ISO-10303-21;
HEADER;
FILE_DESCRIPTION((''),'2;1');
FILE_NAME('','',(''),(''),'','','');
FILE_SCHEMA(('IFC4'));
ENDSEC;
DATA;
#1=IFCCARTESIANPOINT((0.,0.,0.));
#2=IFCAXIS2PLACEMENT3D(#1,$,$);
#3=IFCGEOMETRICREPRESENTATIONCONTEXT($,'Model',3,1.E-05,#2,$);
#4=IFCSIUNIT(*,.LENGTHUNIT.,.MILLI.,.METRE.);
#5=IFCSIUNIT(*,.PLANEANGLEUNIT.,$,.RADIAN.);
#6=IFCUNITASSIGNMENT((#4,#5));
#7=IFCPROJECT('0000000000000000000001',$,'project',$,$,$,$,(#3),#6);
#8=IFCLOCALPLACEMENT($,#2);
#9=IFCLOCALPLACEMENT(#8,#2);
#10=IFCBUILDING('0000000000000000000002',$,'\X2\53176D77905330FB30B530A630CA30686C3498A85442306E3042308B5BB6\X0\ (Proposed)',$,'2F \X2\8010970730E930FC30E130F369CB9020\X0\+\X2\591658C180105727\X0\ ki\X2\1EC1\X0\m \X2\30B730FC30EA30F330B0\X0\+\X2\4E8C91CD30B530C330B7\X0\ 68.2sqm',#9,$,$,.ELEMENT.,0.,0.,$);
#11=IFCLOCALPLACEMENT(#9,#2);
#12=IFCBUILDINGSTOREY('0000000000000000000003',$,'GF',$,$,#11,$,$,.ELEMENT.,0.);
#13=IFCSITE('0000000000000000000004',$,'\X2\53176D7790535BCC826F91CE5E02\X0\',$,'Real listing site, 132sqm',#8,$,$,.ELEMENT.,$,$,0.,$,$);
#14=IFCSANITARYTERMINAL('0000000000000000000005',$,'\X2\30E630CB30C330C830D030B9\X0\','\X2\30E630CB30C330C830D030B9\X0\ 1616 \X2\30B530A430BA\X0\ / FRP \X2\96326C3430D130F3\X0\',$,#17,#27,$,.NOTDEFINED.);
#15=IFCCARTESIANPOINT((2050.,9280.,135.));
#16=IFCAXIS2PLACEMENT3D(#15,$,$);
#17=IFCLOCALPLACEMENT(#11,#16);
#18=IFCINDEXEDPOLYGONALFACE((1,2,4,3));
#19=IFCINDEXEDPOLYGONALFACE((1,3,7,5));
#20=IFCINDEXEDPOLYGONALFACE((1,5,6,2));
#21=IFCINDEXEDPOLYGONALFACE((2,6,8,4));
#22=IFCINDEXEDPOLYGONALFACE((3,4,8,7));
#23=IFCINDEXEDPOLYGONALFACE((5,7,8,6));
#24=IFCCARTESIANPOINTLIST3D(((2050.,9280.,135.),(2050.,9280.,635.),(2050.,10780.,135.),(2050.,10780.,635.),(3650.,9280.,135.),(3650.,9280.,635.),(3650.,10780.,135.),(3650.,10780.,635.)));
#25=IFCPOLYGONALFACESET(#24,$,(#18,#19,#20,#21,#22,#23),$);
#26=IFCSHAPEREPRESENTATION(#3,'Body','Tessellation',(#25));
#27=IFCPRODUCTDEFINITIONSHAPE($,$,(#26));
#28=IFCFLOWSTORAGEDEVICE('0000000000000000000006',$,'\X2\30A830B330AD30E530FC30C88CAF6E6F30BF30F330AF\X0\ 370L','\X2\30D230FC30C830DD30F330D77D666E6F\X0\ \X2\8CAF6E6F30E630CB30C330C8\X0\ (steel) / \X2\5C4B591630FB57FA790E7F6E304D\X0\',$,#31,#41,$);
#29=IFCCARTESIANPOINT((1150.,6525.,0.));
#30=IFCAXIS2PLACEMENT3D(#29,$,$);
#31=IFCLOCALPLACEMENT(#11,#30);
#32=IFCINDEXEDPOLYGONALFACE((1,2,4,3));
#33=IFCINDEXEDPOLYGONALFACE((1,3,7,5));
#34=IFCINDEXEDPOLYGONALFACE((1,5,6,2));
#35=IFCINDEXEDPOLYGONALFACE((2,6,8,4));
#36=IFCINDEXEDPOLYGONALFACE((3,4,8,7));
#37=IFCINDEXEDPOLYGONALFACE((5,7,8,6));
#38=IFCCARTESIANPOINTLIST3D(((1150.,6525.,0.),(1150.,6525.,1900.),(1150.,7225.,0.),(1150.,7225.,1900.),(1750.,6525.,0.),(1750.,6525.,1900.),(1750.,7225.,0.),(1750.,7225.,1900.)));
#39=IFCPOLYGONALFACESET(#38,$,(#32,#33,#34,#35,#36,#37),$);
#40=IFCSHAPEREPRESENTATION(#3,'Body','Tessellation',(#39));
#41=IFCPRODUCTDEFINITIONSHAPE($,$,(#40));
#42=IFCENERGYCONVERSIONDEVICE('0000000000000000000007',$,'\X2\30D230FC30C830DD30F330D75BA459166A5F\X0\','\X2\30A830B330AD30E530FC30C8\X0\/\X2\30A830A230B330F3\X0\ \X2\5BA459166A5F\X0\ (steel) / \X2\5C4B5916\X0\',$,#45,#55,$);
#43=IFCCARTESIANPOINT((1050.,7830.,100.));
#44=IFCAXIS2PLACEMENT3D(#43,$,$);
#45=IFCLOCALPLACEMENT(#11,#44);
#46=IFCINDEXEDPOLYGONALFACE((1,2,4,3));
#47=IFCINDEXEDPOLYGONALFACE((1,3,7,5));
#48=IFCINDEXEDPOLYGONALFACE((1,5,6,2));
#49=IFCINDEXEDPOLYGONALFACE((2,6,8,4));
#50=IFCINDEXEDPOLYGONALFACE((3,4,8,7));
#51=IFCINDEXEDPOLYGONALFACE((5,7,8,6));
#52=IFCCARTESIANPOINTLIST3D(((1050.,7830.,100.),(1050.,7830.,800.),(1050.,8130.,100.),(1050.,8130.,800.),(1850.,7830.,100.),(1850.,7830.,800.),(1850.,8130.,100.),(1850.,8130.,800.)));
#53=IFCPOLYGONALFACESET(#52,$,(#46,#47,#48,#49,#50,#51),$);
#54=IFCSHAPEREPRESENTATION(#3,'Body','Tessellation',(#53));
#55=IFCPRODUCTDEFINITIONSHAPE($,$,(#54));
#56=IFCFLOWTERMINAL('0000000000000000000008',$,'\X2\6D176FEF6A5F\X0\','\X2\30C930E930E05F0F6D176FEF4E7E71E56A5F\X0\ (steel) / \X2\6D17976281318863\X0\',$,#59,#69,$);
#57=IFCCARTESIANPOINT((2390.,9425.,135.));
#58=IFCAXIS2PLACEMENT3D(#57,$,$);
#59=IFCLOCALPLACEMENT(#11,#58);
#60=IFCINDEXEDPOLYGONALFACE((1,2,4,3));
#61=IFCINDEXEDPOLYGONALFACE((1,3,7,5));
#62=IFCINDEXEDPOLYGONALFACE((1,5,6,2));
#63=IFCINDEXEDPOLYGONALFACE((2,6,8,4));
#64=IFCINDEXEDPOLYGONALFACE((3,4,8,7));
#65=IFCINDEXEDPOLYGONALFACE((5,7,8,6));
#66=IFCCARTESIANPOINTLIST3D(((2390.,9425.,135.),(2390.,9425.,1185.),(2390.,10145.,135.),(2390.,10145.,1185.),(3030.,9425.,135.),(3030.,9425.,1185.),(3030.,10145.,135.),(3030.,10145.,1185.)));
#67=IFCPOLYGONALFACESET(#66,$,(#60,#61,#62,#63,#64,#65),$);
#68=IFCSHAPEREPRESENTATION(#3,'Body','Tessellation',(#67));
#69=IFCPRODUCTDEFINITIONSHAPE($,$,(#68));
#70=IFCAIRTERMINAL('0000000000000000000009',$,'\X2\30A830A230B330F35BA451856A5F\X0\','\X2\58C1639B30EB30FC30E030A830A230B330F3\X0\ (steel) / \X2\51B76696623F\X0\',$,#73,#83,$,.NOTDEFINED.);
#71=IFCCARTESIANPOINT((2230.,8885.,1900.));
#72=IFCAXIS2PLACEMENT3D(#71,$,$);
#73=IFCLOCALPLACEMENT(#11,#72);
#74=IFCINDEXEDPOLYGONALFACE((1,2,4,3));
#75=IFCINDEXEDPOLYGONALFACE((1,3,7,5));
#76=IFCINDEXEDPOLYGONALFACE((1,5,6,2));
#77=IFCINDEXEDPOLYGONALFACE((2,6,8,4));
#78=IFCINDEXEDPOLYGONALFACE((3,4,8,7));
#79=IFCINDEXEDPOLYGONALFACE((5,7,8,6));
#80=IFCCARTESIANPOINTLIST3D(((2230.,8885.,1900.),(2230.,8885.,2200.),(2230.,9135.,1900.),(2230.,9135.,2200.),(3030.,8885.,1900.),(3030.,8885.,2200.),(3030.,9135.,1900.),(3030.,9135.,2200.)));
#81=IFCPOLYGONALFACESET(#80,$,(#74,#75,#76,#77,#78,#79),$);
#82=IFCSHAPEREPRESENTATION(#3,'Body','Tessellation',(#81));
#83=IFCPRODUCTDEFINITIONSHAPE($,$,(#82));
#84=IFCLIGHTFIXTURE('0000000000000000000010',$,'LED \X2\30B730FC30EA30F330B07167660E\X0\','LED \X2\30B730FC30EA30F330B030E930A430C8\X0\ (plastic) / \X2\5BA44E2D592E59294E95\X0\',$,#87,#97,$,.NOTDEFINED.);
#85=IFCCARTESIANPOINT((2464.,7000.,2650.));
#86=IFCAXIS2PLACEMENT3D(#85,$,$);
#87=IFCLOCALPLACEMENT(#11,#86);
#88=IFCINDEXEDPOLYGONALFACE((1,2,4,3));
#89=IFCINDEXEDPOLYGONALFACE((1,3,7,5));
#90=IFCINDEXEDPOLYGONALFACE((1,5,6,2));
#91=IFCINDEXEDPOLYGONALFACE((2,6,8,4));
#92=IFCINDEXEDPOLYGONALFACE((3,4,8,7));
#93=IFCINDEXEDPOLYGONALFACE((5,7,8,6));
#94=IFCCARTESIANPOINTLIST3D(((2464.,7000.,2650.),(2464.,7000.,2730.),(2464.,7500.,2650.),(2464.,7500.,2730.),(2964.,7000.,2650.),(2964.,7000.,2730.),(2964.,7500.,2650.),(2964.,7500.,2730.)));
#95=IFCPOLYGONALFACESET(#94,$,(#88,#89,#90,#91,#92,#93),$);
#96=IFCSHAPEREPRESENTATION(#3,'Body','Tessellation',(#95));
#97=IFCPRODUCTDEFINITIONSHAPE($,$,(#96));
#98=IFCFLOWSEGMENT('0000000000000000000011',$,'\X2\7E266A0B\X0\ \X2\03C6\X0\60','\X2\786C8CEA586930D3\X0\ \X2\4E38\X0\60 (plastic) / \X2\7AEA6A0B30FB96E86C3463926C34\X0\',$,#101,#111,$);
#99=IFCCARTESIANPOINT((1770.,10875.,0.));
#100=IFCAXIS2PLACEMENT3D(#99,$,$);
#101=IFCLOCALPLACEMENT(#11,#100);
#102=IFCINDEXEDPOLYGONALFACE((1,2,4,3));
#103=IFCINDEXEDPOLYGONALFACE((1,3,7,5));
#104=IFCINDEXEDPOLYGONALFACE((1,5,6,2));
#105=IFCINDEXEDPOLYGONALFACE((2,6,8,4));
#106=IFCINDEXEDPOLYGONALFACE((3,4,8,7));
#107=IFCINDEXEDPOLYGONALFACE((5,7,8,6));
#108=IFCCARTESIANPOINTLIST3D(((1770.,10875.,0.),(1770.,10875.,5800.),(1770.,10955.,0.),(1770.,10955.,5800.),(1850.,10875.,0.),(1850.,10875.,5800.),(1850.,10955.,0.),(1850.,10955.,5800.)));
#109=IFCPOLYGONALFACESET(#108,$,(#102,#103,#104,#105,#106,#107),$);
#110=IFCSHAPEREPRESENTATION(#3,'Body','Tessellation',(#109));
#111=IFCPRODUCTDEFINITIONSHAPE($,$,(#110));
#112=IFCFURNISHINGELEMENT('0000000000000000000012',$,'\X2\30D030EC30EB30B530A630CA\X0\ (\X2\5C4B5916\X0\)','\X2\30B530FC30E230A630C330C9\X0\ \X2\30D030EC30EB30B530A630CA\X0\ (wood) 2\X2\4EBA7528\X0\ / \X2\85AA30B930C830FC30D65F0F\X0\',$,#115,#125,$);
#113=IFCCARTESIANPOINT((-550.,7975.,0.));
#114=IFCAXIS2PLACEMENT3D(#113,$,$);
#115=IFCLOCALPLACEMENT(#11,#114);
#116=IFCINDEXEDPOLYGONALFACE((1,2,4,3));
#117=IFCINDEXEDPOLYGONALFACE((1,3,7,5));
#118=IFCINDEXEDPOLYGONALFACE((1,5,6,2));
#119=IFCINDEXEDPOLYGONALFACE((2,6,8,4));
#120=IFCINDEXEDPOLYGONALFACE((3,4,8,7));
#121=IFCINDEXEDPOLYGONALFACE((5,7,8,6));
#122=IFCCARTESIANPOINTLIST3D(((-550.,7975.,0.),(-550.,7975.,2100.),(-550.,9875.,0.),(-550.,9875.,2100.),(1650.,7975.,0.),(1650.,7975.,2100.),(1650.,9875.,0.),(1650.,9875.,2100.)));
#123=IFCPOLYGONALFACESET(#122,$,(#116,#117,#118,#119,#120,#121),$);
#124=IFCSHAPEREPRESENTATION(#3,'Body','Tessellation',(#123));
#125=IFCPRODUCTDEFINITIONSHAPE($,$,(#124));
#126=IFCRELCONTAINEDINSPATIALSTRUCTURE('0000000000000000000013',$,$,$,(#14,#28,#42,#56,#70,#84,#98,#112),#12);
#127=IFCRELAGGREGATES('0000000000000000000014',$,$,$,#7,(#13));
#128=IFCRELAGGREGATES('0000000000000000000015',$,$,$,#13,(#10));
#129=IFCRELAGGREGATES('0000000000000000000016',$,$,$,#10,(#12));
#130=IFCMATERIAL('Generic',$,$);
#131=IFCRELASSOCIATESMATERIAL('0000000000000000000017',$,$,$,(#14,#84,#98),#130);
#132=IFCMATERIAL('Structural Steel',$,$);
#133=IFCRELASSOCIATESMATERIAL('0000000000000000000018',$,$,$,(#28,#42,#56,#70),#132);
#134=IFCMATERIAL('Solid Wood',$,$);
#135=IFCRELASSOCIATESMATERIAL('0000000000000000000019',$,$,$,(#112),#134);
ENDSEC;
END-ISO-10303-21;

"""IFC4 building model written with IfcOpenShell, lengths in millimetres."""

from ifc_helpers import new_model, si_unit, frame, frame_2d, origin, place, context, project, spatial, rectangle, extrude, material, element, save


model = new_model("IFC4")

# Units and contexts
model_context = context("Model", 3, precision=1e-05, world=origin())
ifc_project = project(units=[si_unit("LENGTHUNIT", "METRE", prefix="MILLI"), si_unit("PLANEANGLEUNIT", "RADIAN")], contexts=[model_context])

# Site, building, storey
site_placement = place(None, origin())
site = spatial("IfcSite", under=ifc_project, at=site_placement, Name="北海道富良野市", ObjectType="Real listing site, 132sqm", CompositionType="ELEMENT", RefElevation=0.0)
building_placement = place(site_placement, origin())
building = spatial("IfcBuilding", under=site, at=building_placement, Name="北海道・サウナと水風呂のある家 (Proposed)", ObjectType="2F 耐震ラーメン構造+外壁耐圧 kiềm シーリング+二重サッシ 68.2sqm", CompositionType="ELEMENT", ElevationOfRefHeight=0.0, ElevationOfTerrain=0.0)
storey_placement = place(building_placement, origin())
storey = spatial("IfcBuildingStorey", under=building, at=storey_placement, Name="GF", CompositionType="ELEMENT", Elevation=0.0)

# Shared definitions
ifc_material_1 = material(Name="Solid Wood")

# Shared definitions
ifc_material_2 = material(Name="Generic")

# Sanitary terminal
sanitary_terminal_placement = place(storey_placement, frame((2050.0, 9280.0, 135.0)))
element("IfcSanitaryTerminal", 1, at=sanitary_terminal_placement, inside=storey, material=ifc_material_2, Name="ユニットバス", Description="ユニットバス 1616 サイズ / FRP 防水パン", PredefinedType="NOTDEFINED", context=model_context, shape_type="SweptSolid", body=[
    extrude(rectangle(XDim=1600.0, YDim=1500.0, at=frame_2d((800.0, 750.0))), frame((2050.0, 9280.0, 135.0)), (0.0, 0.0, 1.0), 500.0),
])

# Flow storage device
ifc_material_3 = material(Name="Structural Steel")
flow_storage_device_placement = place(storey_placement, frame((1150.0, 6525.0, 0.0)))
element("IfcFlowStorageDevice", 2, at=flow_storage_device_placement, inside=storey, material=ifc_material_3, Name="エコキュート貯湯タンク 370L", Description="ヒートポンプ給湯 貯湯ユニット (steel) / 屋外・基礎置き", context=model_context, shape_type="SweptSolid", body=[
    extrude(rectangle(XDim=600.0, YDim=700.0, at=frame_2d((300.0, 350.0))), frame((1150.0, 6525.0, 0.0)), (0.0, 0.0, 1.0), 1900.0),
])

# Energy conversion device
energy_conversion_device_placement = place(storey_placement, frame((1050.0, 7830.0, 100.0)))
element("IfcEnergyConversionDevice", 3, at=energy_conversion_device_placement, inside=storey, material=ifc_material_3, Name="ヒートポンプ室外機", Description="エコキュート/エアコン 室外機 (steel) / 屋外", context=model_context, shape_type="SweptSolid", body=[
    extrude(rectangle(XDim=800.0, YDim=300.0, at=frame_2d((400.0, 150.0))), frame((1050.0, 7830.0, 100.0)), (0.0, 0.0, 1.0), 700.0),
])

# Flow terminal
flow_terminal_placement = place(storey_placement, frame((2390.0, 9425.0, 135.0)))
element("IfcFlowTerminal", 4, at=flow_terminal_placement, inside=storey, material=ifc_material_3, Name="洗濯機", Description="ドラム式洗濯乾燥機 (steel) / 洗面脱衣", context=model_context, shape_type="SweptSolid", body=[
    extrude(rectangle(XDim=640.0, YDim=720.0, at=frame_2d((320.0, 360.0))), frame((2390.0, 9425.0, 135.0)), (0.0, 0.0, 1.0), 1050.0),
])

# Air terminal
air_terminal_placement = place(storey_placement, frame((2230.0, 8885.0, 1900.0)))
element("IfcAirTerminal", 5, at=air_terminal_placement, inside=storey, material=ifc_material_3, Name="エアコン室内機", Description="壁掛ルームエアコン (steel) / 冷暖房", PredefinedType="NOTDEFINED", context=model_context, shape_type="SweptSolid", body=[
    extrude(rectangle(XDim=800.0, YDim=250.0, at=frame_2d((400.0, 125.0))), frame((2230.0, 8885.0, 1900.0)), (0.0, 0.0, 1.0), 300.0),
])

# Light fixture
light_fixture_placement = place(storey_placement, frame((2464.0, 7000.0, 2650.0)))
element("IfcLightFixture", 6, at=light_fixture_placement, inside=storey, material=ifc_material_2, Name="LED シーリング照明", Description="LED シーリングライト (plastic) / 室中央天井", PredefinedType="NOTDEFINED", context=model_context, shape_type="SweptSolid", body=[
    extrude(rectangle(XDim=500.0, YDim=500.0, at=frame_2d((250.0, 250.0))), frame((2464.0, 7000.0, 2650.0)), (0.0, 0.0, 1.0), 80.0),
])

# Flow segment
flow_segment_placement = place(storey_placement, frame((1770.0, 10875.0, 0.0)))
element("IfcFlowSegment", 7, at=flow_segment_placement, inside=storey, material=ifc_material_2, Name="縦樋 φ60", Description="硬質塩ビ 丸60 (plastic) / 竪樋・雨水排水", context=model_context, shape_type="SweptSolid", body=[
    extrude(rectangle(XDim=80.0, YDim=80.0, at=frame_2d((40.0, 40.0))), frame((1770.0, 10875.0, 0.0)), (0.0, 0.0, 1.0), 5800.0),
])

# Furnishing element
furnishing_placement = place(storey_placement, frame((-550.0, 7975.0, 0.0)))
element("IfcFurnishingElement", 8, at=furnishing_placement, inside=storey, material=ifc_material_1, Name="バレルサウナ (屋外)", Description="サーモウッド バレルサウナ (wood) 2人用 / 薪ストーブ式", context=model_context, shape_type="SweptSolid", body=[
    extrude(rectangle(XDim=2200.0, YDim=1900.0, at=frame_2d((1100.0, 950.0))), frame((-550.0, 7975.0, 0.0)), (0.0, 0.0, 1.0), 2100.0),
])

save(model, "model.ifc")
